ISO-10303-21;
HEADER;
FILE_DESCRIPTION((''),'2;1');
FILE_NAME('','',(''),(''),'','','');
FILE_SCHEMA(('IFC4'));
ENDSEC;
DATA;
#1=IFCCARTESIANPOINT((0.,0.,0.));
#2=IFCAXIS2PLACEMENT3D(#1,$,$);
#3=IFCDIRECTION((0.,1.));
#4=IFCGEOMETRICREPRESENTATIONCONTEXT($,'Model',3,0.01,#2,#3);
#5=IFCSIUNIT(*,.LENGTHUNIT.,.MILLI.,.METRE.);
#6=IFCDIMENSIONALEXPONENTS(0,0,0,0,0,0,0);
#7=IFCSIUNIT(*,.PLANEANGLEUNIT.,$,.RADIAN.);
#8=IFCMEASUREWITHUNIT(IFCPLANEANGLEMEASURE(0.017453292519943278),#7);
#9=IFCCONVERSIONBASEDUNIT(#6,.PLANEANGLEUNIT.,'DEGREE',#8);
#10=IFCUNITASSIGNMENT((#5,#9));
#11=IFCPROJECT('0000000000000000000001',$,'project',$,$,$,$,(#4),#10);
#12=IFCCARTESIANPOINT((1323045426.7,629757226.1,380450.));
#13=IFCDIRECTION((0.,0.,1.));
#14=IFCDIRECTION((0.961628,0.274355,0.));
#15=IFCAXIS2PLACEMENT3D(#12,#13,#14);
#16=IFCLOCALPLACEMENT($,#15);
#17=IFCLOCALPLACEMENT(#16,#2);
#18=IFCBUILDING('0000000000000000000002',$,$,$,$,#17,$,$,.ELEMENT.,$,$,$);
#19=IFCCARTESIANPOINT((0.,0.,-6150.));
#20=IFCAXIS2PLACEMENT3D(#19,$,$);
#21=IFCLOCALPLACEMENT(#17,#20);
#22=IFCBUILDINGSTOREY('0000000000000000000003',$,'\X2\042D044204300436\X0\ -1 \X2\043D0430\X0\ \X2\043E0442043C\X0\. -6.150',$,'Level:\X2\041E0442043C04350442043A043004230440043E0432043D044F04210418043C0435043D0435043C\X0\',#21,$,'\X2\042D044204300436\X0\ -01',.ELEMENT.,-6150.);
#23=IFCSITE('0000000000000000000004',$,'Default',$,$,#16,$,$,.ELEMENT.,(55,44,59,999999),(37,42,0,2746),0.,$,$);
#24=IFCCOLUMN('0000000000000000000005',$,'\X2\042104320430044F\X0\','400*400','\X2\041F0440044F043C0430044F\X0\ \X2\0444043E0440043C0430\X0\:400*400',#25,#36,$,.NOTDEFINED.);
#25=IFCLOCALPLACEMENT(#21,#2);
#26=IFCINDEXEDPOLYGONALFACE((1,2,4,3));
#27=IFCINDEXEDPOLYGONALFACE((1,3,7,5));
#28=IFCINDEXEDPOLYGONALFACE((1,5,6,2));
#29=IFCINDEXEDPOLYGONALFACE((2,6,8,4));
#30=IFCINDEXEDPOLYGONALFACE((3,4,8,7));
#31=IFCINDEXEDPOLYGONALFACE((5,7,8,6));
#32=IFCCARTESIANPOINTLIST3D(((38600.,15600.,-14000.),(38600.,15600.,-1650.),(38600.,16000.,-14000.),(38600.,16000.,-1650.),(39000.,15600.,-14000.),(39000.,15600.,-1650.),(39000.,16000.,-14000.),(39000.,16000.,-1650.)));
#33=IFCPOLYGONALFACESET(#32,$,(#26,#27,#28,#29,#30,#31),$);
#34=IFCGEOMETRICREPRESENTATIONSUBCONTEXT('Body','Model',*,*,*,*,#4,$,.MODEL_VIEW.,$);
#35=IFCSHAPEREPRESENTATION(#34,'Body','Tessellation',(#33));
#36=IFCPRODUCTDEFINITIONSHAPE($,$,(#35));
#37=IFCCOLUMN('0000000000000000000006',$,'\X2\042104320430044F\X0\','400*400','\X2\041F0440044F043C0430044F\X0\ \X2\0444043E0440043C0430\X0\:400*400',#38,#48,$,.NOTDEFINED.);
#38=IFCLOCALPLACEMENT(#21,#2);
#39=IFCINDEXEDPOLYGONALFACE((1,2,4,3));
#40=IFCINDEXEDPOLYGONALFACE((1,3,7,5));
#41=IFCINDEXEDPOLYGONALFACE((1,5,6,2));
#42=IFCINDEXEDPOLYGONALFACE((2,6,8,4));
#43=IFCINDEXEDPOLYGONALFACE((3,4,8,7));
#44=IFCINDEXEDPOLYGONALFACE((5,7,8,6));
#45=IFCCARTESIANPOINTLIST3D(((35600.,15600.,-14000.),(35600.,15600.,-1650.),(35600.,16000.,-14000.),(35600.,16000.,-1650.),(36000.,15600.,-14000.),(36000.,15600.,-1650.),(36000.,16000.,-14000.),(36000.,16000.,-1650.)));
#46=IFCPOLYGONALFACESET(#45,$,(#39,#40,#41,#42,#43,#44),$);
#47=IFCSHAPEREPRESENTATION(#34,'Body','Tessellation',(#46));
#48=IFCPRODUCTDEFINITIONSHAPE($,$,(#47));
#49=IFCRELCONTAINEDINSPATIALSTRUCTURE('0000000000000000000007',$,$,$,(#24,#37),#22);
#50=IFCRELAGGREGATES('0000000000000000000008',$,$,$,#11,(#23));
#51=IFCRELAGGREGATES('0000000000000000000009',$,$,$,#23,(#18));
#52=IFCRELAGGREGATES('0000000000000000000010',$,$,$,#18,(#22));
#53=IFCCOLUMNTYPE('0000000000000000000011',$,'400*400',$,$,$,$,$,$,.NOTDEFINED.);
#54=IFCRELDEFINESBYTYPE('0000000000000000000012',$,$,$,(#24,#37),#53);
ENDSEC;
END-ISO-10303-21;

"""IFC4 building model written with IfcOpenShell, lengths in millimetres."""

from ifc_helpers import new_model, entity, si_unit, converted_unit, direction, frame, origin, place, context, subcontext, project, spatial, indexed_curve, outline, extrude, type_object, element, save


model = new_model("IFC4")

# Units and contexts
model_context = context("Model", 3, precision=0.01, world=origin(), true_north=direction((0.0, 1.0)))
body_context = subcontext(model_context, "Body", "Model", "MODEL_VIEW")
ifc_project = project(units=[si_unit("LENGTHUNIT", "METRE", prefix="MILLI"), converted_unit("PLANEANGLEUNIT", "DEGREE", entity("IfcPlaneAngleMeasure", 0.017453292519943278), si_unit("PLANEANGLEUNIT", "RADIAN"), dimensions=[0, 0, 0, 0, 0, 0, 0])], contexts=[model_context])

# Site, building, storey
site_placement = place(None, frame((1323045426.7, 629757226.1, 380450.0), z_axis=(0.0, 0.0, 1.0), x_axis=(0.961628, 0.274355, 0.0)))
site = spatial("IfcSite", under=ifc_project, at=site_placement, Name="Default", CompositionType="ELEMENT", RefLatitude=(55, 44, 59, 999999), RefLongitude=(37, 42, 0, 2746), RefElevation=0.0)
building_placement = place(site_placement, origin())
building = spatial("IfcBuilding", under=site, at=building_placement, CompositionType="ELEMENT")
storey_placement = place(building_placement, frame((0.0, 0.0, -6150.0)))
storey = spatial("IfcBuildingStorey", under=building, at=storey_placement, Name="Этаж -1 на отм. -6.150", ObjectType="Level:ОтметкаУровняСИменем", LongName="Этаж -01", CompositionType="ELEMENT", Elevation=-6150.0)

# Columns
column_type = type_object("IfcColumnType", Name="400*400", PredefinedType="NOTDEFINED")
column_1_placement = place(storey_placement, origin())
element("IfcColumn", 1, at=column_1_placement, inside=storey, type_object=column_type, Name="Свая", Description="400*400", ObjectType="Прямая форма:400*400", PredefinedType="NOTDEFINED", context=body_context, shape_type="SweptSolid", body=[
    extrude(outline(indexed_curve([(-200.0, -200.0), (200.0, -200.0), (200.0, 200.0), (-200.0, 200.0), (-200.0, -200.0)], self_intersect=False)), frame((38800.0, 15800.0, -14000.0), z_axis=(0.0, 0.0, 1.0), x_axis=(0.0, 1.0, 0.0)), (0.0, 0.0, 1.0), 12350.0),
])
column_2_placement = place(storey_placement, origin())
element("IfcColumn", 2, at=column_2_placement, inside=storey, type_object=column_type, Name="Свая", Description="400*400", ObjectType="Прямая форма:400*400", PredefinedType="NOTDEFINED", context=body_context, shape_type="SweptSolid", body=[
    extrude(outline(indexed_curve([(-200.0, -200.0), (200.0, -200.0), (200.0, 200.0), (-200.0, 200.0), (-200.0, -200.0)], self_intersect=False)), frame((35800.0, 15800.0, -14000.0), z_axis=(0.0, 0.0, 1.0), x_axis=(0.0, 1.0, 0.0)), (0.0, 0.0, 1.0), 12350.0),
])

save(model, "model.ifc")
